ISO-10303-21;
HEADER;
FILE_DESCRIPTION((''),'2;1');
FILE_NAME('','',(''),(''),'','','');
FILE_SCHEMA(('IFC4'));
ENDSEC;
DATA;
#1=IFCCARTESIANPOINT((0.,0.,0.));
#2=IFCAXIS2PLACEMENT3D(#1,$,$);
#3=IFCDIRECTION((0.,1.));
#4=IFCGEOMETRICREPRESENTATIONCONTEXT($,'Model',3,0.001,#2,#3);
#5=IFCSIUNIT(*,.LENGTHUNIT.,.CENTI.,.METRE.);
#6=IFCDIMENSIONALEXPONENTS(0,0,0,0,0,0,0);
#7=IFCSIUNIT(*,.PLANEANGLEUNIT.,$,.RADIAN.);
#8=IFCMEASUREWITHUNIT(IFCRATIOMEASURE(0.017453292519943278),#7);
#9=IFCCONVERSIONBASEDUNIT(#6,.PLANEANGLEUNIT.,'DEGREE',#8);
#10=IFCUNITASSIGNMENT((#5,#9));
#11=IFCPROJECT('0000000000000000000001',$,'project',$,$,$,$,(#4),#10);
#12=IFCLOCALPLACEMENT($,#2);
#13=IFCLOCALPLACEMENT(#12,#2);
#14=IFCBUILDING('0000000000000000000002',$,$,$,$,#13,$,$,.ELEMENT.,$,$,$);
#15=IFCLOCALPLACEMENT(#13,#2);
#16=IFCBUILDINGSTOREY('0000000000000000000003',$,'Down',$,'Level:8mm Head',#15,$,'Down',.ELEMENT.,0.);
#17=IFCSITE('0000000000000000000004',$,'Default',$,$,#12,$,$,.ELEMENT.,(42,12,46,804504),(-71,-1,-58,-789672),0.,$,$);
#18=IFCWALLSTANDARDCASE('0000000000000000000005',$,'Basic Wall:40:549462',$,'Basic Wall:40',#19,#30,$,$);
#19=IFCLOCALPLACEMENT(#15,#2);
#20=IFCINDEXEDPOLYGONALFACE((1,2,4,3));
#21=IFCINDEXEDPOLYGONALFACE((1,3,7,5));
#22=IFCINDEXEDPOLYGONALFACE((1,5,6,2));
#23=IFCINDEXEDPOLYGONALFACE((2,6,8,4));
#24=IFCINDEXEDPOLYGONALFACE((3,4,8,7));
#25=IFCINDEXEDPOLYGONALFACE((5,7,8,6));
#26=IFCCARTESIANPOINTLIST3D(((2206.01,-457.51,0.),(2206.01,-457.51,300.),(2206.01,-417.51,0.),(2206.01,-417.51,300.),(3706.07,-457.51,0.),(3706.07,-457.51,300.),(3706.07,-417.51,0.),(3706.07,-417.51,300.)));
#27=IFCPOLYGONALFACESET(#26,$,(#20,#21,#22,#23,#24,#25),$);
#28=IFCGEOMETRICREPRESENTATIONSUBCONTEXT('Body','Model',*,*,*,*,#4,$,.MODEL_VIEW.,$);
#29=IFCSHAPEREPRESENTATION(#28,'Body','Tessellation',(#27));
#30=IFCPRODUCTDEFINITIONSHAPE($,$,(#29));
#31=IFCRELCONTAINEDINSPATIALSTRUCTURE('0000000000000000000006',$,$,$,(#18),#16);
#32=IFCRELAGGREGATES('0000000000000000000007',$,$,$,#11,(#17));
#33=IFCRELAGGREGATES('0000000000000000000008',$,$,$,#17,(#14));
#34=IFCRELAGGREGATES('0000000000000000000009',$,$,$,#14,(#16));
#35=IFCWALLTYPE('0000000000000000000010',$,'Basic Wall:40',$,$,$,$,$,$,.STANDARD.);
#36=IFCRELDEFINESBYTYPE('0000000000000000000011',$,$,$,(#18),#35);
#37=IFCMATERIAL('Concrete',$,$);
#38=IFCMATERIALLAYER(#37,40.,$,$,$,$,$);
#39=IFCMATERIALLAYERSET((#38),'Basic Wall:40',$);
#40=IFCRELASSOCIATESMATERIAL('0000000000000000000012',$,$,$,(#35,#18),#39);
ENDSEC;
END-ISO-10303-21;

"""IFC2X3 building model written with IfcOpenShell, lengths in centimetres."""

from ifc_helpers import new_model, entity, si_unit, converted_unit, direction, frame, frame_2d, origin, place, context, subcontext, project, spatial, rectangle, extrude, material, layer, layer_set, layer_usage, type_object, element, save


model = new_model("IFC2X3")

# Units and contexts
model_context = context("Model", 3, precision=0.001, world=origin(), true_north=direction((0.0, 1.0)))
body_context = subcontext(model_context, "Body", "Model", "MODEL_VIEW")
ifc_project = project(units=[si_unit("LENGTHUNIT", "METRE", prefix="CENTI"), converted_unit("PLANEANGLEUNIT", "DEGREE", entity("IfcRatioMeasure", 0.017453292519943278), si_unit("PLANEANGLEUNIT", "RADIAN"), dimensions=[0, 0, 0, 0, 0, 0, 0])], contexts=[model_context])

# Site, building, storey
site_placement = place(None, origin())
site = spatial("IfcSite", under=ifc_project, at=site_placement, Name="Default", CompositionType="ELEMENT", RefLatitude=(42, 12, 46, 804504), RefLongitude=(-71, -1, -58, -789672), RefElevation=0.0)
building_placement = place(site_placement, origin())
building = spatial("IfcBuilding", under=site, at=building_placement, CompositionType="ELEMENT")
storey_placement = place(building_placement, origin())
storey = spatial("IfcBuildingStorey", under=building, at=storey_placement, Name="Down", ObjectType="Level:8mm Head", LongName="Down", CompositionType="ELEMENT", Elevation=0.0)

# Shared definitions
ifc_material = material(Name="Concrete")

# Wall
ifc_layer_1 = layer(ifc_material, 40.0)
ifc_layer_set_1 = layer_set([ifc_layer_1], Name="Basic Wall:40")
wall_type_1 = type_object("IfcWallType", Name="Basic Wall:40", PredefinedType="STANDARD", material=ifc_layer_set_1)
ifc_layer_usage_1 = layer_usage(ifc_layer_set_1, "AXIS2", "NEGATIVE", 20.0)
wall_1_placement = place(storey_placement, frame((3706.07, -437.51, 0.0), z_axis=(0.0, 0.0, 1.0), x_axis=(-1.0, 0.0, 0.0)))
element("IfcWallStandardCase", 1, at=wall_1_placement, inside=storey, type_object=wall_type_1, material=ifc_layer_usage_1, Name="Basic Wall:40:549462", ObjectType="Basic Wall:40", context=body_context, shape_type="SweptSolid", body=[
    extrude(rectangle(XDim=1500.06, YDim=40.0, at=frame_2d((750.03, 0.0), x_axis=(-1.0, 0.0))), origin(), (0.0, 0.0, 1.0), 300.0),
])

save(model, "model.ifc")
